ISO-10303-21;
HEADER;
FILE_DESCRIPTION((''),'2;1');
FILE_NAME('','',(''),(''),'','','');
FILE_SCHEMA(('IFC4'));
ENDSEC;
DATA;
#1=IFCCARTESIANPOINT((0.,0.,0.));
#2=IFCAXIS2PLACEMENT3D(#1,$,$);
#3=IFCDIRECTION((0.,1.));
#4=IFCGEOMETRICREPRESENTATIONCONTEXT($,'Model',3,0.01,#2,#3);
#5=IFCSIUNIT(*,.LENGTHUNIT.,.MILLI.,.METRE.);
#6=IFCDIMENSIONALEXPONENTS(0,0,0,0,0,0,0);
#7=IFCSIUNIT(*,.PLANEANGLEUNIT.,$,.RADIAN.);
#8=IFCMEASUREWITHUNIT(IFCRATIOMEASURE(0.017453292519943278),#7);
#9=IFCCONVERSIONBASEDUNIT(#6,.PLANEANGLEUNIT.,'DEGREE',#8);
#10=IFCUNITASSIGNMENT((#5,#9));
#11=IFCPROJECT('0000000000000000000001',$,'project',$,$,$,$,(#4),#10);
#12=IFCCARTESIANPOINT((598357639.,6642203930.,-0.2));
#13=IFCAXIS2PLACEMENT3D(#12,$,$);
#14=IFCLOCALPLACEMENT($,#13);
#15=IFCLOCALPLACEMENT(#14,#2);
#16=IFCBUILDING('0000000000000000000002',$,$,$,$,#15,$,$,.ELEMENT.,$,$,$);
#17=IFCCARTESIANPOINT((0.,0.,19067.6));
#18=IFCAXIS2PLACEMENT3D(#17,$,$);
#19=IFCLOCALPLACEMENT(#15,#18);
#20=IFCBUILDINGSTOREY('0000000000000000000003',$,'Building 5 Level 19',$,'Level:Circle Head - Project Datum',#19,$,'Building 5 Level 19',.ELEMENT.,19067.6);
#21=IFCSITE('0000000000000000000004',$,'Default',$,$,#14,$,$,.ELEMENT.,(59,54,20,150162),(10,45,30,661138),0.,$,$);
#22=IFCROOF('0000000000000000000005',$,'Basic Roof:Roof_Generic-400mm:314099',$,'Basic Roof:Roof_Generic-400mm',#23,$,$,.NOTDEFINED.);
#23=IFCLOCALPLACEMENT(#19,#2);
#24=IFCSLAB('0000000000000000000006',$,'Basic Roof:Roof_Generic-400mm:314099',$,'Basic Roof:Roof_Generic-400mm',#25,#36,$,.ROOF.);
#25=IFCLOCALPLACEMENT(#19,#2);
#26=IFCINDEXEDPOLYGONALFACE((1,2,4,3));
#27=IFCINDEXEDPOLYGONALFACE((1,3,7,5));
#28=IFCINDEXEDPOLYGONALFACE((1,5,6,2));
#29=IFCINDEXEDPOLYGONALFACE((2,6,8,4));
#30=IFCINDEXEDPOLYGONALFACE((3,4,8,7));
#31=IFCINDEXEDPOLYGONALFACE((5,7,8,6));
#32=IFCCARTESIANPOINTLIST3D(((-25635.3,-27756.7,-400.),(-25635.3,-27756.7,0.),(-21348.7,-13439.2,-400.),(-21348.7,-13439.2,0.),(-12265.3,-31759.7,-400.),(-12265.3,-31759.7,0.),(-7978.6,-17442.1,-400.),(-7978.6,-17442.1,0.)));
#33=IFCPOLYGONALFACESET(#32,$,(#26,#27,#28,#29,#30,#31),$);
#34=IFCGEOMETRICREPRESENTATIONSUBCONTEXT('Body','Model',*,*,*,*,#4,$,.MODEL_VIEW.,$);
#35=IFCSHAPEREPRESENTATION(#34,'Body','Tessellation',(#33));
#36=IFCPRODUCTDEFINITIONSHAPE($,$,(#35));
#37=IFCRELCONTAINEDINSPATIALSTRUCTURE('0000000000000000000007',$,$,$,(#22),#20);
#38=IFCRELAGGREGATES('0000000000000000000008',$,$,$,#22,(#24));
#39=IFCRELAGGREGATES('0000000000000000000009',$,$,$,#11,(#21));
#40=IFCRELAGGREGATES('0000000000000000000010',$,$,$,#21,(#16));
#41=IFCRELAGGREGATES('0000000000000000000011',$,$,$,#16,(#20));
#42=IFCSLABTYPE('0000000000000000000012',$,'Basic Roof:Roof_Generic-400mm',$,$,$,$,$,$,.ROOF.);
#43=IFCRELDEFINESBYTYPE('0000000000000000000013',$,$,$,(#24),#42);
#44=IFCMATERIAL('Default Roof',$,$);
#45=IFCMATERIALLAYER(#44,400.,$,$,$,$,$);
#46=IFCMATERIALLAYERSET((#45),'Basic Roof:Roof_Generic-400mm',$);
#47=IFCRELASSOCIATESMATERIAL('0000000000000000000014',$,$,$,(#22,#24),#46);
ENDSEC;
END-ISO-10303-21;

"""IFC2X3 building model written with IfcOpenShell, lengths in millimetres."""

from ifc_helpers import new_model, entity, si_unit, converted_unit, direction, frame, frame_2d, origin, place, context, subcontext, project, spatial, rectangle, extrude, material, layer, layer_set, type_object, element, aggregate, save


model = new_model("IFC2X3")

# Units and contexts
model_context = context("Model", 3, precision=0.01, world=origin(), true_north=direction((0.0, 1.0)))
body_context = subcontext(model_context, "Body", "Model", "MODEL_VIEW")
ifc_project = project(units=[si_unit("LENGTHUNIT", "METRE", prefix="MILLI"), converted_unit("PLANEANGLEUNIT", "DEGREE", entity("IfcRatioMeasure", 0.017453292519943278), si_unit("PLANEANGLEUNIT", "RADIAN"), dimensions=[0, 0, 0, 0, 0, 0, 0])], contexts=[model_context])

# Site, building, storey
site_placement = place(None, frame((598357639.0, 6642203930.0, -0.2)))
site = spatial("IfcSite", under=ifc_project, at=site_placement, Name="Default", CompositionType="ELEMENT", RefLatitude=(59, 54, 20, 150162), RefLongitude=(10, 45, 30, 661138), RefElevation=0.0)
building_placement = place(site_placement, origin())
building = spatial("IfcBuilding", under=site, at=building_placement, CompositionType="ELEMENT")
storey_placement = place(building_placement, frame((0.0, 0.0, 19067.6)))
storey = spatial("IfcBuildingStorey", under=building, at=storey_placement, Name="Building 5 Level 19", ObjectType="Level:Circle Head - Project Datum", LongName="Building 5 Level 19", CompositionType="ELEMENT", Elevation=19067.6)

# Roof, slab
ifc_material = material(Name="Default Roof")
ifc_layer = layer(ifc_material, 400.0)
ifc_layer_set = layer_set([ifc_layer], Name="Basic Roof:Roof_Generic-400mm")
roof_placement = place(storey_placement, frame((-25635.3, -31759.7, -400.0)))
roof = element("IfcRoof", 1, at=roof_placement, inside=storey, material=ifc_layer_set, Name="Basic Roof:Roof_Generic-400mm:314099", ObjectType="Basic Roof:Roof_Generic-400mm", ShapeType="NOTDEFINED")
slab_type = type_object("IfcSlabType", Name="Basic Roof:Roof_Generic-400mm", PredefinedType="ROOF")
slab_placement = place(roof_placement, origin())
slab = element("IfcSlab", 2, at=slab_placement, type_object=slab_type, material=ifc_layer_set, Name="Basic Roof:Roof_Generic-400mm:314099", ObjectType="Basic Roof:Roof_Generic-400mm", PredefinedType="ROOF", context=body_context, shape_type="SweptSolid", body=[
    extrude(rectangle(XDim=13956.4, YDim=14945.5, at=frame_2d((0.0, 0.0), x_axis=(-0.957985, 0.286817))), frame((8828.3, 9160.2, 0.0)), (0.0, 0.0, 1.0), 400.0),
])
aggregate(roof, [slab])

save(model, "model.ifc")
